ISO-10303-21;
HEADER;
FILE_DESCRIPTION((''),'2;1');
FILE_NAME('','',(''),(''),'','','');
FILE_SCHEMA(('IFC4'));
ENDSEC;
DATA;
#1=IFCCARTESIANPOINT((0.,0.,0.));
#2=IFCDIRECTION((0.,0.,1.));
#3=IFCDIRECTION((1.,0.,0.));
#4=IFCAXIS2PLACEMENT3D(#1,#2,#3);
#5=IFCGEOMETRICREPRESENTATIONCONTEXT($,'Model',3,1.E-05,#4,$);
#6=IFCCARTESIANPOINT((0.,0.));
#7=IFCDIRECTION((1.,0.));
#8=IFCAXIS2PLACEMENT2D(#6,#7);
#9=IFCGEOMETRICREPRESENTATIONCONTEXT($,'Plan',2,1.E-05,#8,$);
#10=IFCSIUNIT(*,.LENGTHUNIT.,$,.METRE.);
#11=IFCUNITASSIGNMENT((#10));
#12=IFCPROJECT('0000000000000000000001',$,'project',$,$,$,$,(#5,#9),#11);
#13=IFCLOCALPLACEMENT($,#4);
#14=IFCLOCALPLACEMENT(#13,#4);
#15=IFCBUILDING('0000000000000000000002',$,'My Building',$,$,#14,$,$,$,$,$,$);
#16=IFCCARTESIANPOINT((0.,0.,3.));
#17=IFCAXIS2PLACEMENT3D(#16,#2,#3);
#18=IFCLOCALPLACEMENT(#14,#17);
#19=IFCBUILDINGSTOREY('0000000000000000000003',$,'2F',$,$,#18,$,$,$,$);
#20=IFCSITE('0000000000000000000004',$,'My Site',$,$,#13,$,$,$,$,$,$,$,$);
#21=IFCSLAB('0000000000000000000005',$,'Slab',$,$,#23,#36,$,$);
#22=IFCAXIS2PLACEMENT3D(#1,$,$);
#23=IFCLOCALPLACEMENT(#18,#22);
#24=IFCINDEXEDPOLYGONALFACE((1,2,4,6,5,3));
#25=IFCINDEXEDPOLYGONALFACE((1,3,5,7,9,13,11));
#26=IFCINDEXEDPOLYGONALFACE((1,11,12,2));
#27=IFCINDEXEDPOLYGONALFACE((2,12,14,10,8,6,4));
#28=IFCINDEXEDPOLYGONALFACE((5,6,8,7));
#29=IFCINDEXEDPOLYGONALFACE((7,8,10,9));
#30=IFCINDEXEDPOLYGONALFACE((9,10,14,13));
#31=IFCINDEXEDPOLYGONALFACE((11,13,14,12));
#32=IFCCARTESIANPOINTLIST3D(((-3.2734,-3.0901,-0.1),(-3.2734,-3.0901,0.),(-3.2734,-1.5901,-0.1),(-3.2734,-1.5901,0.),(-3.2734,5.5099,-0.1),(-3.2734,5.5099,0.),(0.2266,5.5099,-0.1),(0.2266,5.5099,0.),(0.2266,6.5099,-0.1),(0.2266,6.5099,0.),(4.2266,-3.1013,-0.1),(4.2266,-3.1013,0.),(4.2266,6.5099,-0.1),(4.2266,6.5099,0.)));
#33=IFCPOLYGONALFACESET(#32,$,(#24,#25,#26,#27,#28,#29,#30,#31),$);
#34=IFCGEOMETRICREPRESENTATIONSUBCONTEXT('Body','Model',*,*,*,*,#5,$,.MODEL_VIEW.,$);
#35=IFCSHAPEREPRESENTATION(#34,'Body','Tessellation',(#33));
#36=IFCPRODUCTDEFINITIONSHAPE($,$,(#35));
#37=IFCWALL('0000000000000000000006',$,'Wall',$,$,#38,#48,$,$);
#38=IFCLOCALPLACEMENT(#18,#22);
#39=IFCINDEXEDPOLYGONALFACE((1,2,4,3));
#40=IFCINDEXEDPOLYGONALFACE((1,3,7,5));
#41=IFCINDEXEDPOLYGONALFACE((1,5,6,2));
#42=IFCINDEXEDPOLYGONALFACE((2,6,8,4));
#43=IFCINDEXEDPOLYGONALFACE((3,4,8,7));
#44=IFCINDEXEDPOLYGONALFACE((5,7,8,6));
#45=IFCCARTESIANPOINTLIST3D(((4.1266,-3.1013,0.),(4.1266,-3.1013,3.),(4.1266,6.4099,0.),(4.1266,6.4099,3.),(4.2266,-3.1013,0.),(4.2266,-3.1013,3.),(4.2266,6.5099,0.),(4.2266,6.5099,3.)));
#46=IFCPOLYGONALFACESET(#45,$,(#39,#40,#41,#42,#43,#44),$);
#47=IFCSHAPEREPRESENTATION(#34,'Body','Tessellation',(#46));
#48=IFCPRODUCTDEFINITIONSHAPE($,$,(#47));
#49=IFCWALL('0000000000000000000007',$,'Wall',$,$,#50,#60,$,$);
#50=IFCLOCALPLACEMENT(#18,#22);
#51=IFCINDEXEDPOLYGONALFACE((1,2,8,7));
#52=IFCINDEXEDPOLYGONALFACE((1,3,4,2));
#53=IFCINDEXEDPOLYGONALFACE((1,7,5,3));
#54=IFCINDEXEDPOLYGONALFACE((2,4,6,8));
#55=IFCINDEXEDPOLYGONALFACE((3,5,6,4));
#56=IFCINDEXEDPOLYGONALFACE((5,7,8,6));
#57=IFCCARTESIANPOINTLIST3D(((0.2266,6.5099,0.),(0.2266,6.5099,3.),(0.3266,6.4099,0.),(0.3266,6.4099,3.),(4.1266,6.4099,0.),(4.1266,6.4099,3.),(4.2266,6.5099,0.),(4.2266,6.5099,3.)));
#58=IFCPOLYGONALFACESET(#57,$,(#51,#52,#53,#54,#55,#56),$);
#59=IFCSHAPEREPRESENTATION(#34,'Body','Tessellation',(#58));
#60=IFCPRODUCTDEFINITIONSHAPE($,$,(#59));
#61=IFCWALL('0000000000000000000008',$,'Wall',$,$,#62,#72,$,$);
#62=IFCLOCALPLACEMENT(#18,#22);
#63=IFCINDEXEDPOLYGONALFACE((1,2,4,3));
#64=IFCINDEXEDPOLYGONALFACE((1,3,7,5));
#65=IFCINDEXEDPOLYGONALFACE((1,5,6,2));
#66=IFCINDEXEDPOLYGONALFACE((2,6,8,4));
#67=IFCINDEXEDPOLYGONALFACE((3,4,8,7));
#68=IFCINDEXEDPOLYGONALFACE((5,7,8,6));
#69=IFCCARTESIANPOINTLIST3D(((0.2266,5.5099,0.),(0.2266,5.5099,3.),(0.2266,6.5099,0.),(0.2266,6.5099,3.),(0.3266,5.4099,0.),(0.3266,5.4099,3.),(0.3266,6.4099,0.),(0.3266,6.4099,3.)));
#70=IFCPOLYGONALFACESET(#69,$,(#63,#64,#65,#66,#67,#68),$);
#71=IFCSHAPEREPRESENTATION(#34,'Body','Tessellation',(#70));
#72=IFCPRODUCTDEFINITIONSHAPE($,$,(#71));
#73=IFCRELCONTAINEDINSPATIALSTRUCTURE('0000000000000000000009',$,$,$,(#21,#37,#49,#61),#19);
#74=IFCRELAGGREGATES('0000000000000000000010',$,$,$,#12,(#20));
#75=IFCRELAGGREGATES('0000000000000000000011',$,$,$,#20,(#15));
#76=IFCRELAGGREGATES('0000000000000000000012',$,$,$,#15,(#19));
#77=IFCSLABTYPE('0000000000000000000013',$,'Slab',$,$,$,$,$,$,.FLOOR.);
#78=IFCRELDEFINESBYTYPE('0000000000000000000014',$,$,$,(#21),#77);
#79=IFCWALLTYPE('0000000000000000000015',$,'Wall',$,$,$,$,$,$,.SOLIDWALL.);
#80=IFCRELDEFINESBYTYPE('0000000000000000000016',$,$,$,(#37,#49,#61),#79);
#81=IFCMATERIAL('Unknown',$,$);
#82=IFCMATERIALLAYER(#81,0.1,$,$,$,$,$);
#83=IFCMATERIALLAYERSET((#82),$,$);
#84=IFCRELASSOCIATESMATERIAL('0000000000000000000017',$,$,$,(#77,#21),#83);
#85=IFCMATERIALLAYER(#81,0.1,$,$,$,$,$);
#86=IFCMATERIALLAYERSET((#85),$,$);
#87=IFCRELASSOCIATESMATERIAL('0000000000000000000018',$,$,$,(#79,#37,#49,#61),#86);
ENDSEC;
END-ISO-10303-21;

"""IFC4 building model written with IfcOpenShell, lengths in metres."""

from ifc_helpers import new_model, si_unit, frame, origin_with_axes, origin_2d_with_axis, place, context, subcontext, project, spatial, line, indexed_curve, outline, extrude, material, layer, layer_set, layer_usage, type_object, element, save


model = new_model("IFC4")

# Units and contexts
model_context = context("Model", 3, precision=1e-05, world=origin_with_axes())
plan_context = context("Plan", 2, precision=1e-05, world=origin_2d_with_axis())
body_context_1 = subcontext(model_context, "Body", "Model", "MODEL_VIEW")
ifc_project = project(units=[si_unit("LENGTHUNIT", "METRE")], contexts=[model_context, plan_context])

# Site, building, storey
site_placement = place(None, origin_with_axes())
site = spatial("IfcSite", under=ifc_project, at=site_placement, Name="My Site")
building_placement = place(site_placement, origin_with_axes())
building = spatial("IfcBuilding", under=site, at=building_placement, Name="My Building")
storey_placement = place(building_placement, frame((0.0, 0.0, 3.0), z_axis=(0.0, 0.0, 1.0), x_axis=(1.0, 0.0, 0.0)))
storey = spatial("IfcBuildingStorey", under=building, at=storey_placement, Name="2F")

# Slab
ifc_material = material(Name="Unknown")
ifc_layer_1 = layer(ifc_material, 0.1)
ifc_layer_set_1 = layer_set([ifc_layer_1])
ifc_layer_usage_1 = layer_usage(ifc_layer_set_1, "AXIS3", "POSITIVE", -0.1)
slab_type = type_object("IfcSlabType", Name="Slab", PredefinedType="FLOOR", material=ifc_layer_set_1)
slab_placement = place(storey_placement, frame((4.2266, -3.1013, 0.0), z_axis=(0.0, 0.0, 1.0), x_axis=(1.0, 0.0, 0.0)))
element("IfcSlab", 1, at=slab_placement, inside=storey, type_object=slab_type, material=ifc_layer_usage_1, Name="Slab", context=body_context_1, shape_type="SweptSolid", body=[
    extrude(outline(indexed_curve([(0.0, 0.0), (0.0, 9.6112), (-4.0, 9.6112), (-4.0, 8.6112), (-7.5, 8.6112), (-7.5, 1.5112), (-7.5, 0.0112), (0.0, 0.0)])), frame((0.0, 0.0, -0.1), z_axis=(0.0, 0.0, 1.0), x_axis=(1.0, 0.0, 0.0)), (0.0, 0.0, 1.0), 0.1),
])

# Walls
ifc_layer_2 = layer(ifc_material, 0.1)
ifc_layer_set_2 = layer_set([ifc_layer_2])
ifc_layer_usage_2 = layer_usage(ifc_layer_set_2, "AXIS2", "POSITIVE", 0.0)
wall_type = type_object("IfcWallType", Name="Wall", PredefinedType="SOLIDWALL", material=ifc_layer_set_2)
wall_1_placement = place(storey_placement, frame((4.2266, -3.1013, 0.0), z_axis=(0.0, 0.0, 1.0), x_axis=(0.0, 1.0, 0.0)))
element("IfcWall", 2, at=wall_1_placement, inside=storey, type_object=wall_type, material=ifc_layer_usage_2, Name="Wall", context=body_context_1, shape_type="SweptSolid", body=[
    extrude(outline(indexed_curve([(0.0, 0.0), (0.0, 0.1), (9.5112, 0.1), (9.6112, 0.0)], segments=[line(1, 2, 3, 4, 1)])), origin_with_axes(), (0.0, 0.0, 1.0), 3.0),
])
ifc_layer_usage_3 = layer_usage(ifc_layer_set_2, "AXIS2", "POSITIVE", 0.0)
wall_2_placement = place(storey_placement, frame((4.2266, 6.5099, 0.0), z_axis=(0.0, 0.0, 1.0), x_axis=(-1.0, 0.0, 0.0)))
element("IfcWall", 3, at=wall_2_placement, inside=storey, type_object=wall_type, material=ifc_layer_usage_3, Name="Wall", context=body_context_1, shape_type="SweptSolid", body=[
    extrude(outline(indexed_curve([(0.0, 0.0), (0.1, 0.1), (3.9, 0.1), (4.0, 0.0)], segments=[line(1, 2, 3, 4, 1)])), origin_with_axes(), (0.0, 0.0, 1.0), 3.0),
])
ifc_layer_usage_4 = layer_usage(ifc_layer_set_2, "AXIS2", "POSITIVE", 0.0)
wall_3_placement = place(storey_placement, frame((0.2266, 6.5099, 0.0), z_axis=(0.0, 0.0, 1.0), x_axis=(0.0, -1.0, 0.0)))
element("IfcWall", 4, at=wall_3_placement, inside=storey, type_object=wall_type, material=ifc_layer_usage_4, Name="Wall", context=body_context_1, shape_type="SweptSolid", body=[
    extrude(outline(indexed_curve([(0.0, 0.0), (0.1, 0.1), (1.1, 0.1), (1.0, 0.0)], segments=[line(1, 2, 3, 4, 1)])), origin_with_axes(), (0.0, 0.0, 1.0), 3.0),
])

save(model, "model.ifc")
